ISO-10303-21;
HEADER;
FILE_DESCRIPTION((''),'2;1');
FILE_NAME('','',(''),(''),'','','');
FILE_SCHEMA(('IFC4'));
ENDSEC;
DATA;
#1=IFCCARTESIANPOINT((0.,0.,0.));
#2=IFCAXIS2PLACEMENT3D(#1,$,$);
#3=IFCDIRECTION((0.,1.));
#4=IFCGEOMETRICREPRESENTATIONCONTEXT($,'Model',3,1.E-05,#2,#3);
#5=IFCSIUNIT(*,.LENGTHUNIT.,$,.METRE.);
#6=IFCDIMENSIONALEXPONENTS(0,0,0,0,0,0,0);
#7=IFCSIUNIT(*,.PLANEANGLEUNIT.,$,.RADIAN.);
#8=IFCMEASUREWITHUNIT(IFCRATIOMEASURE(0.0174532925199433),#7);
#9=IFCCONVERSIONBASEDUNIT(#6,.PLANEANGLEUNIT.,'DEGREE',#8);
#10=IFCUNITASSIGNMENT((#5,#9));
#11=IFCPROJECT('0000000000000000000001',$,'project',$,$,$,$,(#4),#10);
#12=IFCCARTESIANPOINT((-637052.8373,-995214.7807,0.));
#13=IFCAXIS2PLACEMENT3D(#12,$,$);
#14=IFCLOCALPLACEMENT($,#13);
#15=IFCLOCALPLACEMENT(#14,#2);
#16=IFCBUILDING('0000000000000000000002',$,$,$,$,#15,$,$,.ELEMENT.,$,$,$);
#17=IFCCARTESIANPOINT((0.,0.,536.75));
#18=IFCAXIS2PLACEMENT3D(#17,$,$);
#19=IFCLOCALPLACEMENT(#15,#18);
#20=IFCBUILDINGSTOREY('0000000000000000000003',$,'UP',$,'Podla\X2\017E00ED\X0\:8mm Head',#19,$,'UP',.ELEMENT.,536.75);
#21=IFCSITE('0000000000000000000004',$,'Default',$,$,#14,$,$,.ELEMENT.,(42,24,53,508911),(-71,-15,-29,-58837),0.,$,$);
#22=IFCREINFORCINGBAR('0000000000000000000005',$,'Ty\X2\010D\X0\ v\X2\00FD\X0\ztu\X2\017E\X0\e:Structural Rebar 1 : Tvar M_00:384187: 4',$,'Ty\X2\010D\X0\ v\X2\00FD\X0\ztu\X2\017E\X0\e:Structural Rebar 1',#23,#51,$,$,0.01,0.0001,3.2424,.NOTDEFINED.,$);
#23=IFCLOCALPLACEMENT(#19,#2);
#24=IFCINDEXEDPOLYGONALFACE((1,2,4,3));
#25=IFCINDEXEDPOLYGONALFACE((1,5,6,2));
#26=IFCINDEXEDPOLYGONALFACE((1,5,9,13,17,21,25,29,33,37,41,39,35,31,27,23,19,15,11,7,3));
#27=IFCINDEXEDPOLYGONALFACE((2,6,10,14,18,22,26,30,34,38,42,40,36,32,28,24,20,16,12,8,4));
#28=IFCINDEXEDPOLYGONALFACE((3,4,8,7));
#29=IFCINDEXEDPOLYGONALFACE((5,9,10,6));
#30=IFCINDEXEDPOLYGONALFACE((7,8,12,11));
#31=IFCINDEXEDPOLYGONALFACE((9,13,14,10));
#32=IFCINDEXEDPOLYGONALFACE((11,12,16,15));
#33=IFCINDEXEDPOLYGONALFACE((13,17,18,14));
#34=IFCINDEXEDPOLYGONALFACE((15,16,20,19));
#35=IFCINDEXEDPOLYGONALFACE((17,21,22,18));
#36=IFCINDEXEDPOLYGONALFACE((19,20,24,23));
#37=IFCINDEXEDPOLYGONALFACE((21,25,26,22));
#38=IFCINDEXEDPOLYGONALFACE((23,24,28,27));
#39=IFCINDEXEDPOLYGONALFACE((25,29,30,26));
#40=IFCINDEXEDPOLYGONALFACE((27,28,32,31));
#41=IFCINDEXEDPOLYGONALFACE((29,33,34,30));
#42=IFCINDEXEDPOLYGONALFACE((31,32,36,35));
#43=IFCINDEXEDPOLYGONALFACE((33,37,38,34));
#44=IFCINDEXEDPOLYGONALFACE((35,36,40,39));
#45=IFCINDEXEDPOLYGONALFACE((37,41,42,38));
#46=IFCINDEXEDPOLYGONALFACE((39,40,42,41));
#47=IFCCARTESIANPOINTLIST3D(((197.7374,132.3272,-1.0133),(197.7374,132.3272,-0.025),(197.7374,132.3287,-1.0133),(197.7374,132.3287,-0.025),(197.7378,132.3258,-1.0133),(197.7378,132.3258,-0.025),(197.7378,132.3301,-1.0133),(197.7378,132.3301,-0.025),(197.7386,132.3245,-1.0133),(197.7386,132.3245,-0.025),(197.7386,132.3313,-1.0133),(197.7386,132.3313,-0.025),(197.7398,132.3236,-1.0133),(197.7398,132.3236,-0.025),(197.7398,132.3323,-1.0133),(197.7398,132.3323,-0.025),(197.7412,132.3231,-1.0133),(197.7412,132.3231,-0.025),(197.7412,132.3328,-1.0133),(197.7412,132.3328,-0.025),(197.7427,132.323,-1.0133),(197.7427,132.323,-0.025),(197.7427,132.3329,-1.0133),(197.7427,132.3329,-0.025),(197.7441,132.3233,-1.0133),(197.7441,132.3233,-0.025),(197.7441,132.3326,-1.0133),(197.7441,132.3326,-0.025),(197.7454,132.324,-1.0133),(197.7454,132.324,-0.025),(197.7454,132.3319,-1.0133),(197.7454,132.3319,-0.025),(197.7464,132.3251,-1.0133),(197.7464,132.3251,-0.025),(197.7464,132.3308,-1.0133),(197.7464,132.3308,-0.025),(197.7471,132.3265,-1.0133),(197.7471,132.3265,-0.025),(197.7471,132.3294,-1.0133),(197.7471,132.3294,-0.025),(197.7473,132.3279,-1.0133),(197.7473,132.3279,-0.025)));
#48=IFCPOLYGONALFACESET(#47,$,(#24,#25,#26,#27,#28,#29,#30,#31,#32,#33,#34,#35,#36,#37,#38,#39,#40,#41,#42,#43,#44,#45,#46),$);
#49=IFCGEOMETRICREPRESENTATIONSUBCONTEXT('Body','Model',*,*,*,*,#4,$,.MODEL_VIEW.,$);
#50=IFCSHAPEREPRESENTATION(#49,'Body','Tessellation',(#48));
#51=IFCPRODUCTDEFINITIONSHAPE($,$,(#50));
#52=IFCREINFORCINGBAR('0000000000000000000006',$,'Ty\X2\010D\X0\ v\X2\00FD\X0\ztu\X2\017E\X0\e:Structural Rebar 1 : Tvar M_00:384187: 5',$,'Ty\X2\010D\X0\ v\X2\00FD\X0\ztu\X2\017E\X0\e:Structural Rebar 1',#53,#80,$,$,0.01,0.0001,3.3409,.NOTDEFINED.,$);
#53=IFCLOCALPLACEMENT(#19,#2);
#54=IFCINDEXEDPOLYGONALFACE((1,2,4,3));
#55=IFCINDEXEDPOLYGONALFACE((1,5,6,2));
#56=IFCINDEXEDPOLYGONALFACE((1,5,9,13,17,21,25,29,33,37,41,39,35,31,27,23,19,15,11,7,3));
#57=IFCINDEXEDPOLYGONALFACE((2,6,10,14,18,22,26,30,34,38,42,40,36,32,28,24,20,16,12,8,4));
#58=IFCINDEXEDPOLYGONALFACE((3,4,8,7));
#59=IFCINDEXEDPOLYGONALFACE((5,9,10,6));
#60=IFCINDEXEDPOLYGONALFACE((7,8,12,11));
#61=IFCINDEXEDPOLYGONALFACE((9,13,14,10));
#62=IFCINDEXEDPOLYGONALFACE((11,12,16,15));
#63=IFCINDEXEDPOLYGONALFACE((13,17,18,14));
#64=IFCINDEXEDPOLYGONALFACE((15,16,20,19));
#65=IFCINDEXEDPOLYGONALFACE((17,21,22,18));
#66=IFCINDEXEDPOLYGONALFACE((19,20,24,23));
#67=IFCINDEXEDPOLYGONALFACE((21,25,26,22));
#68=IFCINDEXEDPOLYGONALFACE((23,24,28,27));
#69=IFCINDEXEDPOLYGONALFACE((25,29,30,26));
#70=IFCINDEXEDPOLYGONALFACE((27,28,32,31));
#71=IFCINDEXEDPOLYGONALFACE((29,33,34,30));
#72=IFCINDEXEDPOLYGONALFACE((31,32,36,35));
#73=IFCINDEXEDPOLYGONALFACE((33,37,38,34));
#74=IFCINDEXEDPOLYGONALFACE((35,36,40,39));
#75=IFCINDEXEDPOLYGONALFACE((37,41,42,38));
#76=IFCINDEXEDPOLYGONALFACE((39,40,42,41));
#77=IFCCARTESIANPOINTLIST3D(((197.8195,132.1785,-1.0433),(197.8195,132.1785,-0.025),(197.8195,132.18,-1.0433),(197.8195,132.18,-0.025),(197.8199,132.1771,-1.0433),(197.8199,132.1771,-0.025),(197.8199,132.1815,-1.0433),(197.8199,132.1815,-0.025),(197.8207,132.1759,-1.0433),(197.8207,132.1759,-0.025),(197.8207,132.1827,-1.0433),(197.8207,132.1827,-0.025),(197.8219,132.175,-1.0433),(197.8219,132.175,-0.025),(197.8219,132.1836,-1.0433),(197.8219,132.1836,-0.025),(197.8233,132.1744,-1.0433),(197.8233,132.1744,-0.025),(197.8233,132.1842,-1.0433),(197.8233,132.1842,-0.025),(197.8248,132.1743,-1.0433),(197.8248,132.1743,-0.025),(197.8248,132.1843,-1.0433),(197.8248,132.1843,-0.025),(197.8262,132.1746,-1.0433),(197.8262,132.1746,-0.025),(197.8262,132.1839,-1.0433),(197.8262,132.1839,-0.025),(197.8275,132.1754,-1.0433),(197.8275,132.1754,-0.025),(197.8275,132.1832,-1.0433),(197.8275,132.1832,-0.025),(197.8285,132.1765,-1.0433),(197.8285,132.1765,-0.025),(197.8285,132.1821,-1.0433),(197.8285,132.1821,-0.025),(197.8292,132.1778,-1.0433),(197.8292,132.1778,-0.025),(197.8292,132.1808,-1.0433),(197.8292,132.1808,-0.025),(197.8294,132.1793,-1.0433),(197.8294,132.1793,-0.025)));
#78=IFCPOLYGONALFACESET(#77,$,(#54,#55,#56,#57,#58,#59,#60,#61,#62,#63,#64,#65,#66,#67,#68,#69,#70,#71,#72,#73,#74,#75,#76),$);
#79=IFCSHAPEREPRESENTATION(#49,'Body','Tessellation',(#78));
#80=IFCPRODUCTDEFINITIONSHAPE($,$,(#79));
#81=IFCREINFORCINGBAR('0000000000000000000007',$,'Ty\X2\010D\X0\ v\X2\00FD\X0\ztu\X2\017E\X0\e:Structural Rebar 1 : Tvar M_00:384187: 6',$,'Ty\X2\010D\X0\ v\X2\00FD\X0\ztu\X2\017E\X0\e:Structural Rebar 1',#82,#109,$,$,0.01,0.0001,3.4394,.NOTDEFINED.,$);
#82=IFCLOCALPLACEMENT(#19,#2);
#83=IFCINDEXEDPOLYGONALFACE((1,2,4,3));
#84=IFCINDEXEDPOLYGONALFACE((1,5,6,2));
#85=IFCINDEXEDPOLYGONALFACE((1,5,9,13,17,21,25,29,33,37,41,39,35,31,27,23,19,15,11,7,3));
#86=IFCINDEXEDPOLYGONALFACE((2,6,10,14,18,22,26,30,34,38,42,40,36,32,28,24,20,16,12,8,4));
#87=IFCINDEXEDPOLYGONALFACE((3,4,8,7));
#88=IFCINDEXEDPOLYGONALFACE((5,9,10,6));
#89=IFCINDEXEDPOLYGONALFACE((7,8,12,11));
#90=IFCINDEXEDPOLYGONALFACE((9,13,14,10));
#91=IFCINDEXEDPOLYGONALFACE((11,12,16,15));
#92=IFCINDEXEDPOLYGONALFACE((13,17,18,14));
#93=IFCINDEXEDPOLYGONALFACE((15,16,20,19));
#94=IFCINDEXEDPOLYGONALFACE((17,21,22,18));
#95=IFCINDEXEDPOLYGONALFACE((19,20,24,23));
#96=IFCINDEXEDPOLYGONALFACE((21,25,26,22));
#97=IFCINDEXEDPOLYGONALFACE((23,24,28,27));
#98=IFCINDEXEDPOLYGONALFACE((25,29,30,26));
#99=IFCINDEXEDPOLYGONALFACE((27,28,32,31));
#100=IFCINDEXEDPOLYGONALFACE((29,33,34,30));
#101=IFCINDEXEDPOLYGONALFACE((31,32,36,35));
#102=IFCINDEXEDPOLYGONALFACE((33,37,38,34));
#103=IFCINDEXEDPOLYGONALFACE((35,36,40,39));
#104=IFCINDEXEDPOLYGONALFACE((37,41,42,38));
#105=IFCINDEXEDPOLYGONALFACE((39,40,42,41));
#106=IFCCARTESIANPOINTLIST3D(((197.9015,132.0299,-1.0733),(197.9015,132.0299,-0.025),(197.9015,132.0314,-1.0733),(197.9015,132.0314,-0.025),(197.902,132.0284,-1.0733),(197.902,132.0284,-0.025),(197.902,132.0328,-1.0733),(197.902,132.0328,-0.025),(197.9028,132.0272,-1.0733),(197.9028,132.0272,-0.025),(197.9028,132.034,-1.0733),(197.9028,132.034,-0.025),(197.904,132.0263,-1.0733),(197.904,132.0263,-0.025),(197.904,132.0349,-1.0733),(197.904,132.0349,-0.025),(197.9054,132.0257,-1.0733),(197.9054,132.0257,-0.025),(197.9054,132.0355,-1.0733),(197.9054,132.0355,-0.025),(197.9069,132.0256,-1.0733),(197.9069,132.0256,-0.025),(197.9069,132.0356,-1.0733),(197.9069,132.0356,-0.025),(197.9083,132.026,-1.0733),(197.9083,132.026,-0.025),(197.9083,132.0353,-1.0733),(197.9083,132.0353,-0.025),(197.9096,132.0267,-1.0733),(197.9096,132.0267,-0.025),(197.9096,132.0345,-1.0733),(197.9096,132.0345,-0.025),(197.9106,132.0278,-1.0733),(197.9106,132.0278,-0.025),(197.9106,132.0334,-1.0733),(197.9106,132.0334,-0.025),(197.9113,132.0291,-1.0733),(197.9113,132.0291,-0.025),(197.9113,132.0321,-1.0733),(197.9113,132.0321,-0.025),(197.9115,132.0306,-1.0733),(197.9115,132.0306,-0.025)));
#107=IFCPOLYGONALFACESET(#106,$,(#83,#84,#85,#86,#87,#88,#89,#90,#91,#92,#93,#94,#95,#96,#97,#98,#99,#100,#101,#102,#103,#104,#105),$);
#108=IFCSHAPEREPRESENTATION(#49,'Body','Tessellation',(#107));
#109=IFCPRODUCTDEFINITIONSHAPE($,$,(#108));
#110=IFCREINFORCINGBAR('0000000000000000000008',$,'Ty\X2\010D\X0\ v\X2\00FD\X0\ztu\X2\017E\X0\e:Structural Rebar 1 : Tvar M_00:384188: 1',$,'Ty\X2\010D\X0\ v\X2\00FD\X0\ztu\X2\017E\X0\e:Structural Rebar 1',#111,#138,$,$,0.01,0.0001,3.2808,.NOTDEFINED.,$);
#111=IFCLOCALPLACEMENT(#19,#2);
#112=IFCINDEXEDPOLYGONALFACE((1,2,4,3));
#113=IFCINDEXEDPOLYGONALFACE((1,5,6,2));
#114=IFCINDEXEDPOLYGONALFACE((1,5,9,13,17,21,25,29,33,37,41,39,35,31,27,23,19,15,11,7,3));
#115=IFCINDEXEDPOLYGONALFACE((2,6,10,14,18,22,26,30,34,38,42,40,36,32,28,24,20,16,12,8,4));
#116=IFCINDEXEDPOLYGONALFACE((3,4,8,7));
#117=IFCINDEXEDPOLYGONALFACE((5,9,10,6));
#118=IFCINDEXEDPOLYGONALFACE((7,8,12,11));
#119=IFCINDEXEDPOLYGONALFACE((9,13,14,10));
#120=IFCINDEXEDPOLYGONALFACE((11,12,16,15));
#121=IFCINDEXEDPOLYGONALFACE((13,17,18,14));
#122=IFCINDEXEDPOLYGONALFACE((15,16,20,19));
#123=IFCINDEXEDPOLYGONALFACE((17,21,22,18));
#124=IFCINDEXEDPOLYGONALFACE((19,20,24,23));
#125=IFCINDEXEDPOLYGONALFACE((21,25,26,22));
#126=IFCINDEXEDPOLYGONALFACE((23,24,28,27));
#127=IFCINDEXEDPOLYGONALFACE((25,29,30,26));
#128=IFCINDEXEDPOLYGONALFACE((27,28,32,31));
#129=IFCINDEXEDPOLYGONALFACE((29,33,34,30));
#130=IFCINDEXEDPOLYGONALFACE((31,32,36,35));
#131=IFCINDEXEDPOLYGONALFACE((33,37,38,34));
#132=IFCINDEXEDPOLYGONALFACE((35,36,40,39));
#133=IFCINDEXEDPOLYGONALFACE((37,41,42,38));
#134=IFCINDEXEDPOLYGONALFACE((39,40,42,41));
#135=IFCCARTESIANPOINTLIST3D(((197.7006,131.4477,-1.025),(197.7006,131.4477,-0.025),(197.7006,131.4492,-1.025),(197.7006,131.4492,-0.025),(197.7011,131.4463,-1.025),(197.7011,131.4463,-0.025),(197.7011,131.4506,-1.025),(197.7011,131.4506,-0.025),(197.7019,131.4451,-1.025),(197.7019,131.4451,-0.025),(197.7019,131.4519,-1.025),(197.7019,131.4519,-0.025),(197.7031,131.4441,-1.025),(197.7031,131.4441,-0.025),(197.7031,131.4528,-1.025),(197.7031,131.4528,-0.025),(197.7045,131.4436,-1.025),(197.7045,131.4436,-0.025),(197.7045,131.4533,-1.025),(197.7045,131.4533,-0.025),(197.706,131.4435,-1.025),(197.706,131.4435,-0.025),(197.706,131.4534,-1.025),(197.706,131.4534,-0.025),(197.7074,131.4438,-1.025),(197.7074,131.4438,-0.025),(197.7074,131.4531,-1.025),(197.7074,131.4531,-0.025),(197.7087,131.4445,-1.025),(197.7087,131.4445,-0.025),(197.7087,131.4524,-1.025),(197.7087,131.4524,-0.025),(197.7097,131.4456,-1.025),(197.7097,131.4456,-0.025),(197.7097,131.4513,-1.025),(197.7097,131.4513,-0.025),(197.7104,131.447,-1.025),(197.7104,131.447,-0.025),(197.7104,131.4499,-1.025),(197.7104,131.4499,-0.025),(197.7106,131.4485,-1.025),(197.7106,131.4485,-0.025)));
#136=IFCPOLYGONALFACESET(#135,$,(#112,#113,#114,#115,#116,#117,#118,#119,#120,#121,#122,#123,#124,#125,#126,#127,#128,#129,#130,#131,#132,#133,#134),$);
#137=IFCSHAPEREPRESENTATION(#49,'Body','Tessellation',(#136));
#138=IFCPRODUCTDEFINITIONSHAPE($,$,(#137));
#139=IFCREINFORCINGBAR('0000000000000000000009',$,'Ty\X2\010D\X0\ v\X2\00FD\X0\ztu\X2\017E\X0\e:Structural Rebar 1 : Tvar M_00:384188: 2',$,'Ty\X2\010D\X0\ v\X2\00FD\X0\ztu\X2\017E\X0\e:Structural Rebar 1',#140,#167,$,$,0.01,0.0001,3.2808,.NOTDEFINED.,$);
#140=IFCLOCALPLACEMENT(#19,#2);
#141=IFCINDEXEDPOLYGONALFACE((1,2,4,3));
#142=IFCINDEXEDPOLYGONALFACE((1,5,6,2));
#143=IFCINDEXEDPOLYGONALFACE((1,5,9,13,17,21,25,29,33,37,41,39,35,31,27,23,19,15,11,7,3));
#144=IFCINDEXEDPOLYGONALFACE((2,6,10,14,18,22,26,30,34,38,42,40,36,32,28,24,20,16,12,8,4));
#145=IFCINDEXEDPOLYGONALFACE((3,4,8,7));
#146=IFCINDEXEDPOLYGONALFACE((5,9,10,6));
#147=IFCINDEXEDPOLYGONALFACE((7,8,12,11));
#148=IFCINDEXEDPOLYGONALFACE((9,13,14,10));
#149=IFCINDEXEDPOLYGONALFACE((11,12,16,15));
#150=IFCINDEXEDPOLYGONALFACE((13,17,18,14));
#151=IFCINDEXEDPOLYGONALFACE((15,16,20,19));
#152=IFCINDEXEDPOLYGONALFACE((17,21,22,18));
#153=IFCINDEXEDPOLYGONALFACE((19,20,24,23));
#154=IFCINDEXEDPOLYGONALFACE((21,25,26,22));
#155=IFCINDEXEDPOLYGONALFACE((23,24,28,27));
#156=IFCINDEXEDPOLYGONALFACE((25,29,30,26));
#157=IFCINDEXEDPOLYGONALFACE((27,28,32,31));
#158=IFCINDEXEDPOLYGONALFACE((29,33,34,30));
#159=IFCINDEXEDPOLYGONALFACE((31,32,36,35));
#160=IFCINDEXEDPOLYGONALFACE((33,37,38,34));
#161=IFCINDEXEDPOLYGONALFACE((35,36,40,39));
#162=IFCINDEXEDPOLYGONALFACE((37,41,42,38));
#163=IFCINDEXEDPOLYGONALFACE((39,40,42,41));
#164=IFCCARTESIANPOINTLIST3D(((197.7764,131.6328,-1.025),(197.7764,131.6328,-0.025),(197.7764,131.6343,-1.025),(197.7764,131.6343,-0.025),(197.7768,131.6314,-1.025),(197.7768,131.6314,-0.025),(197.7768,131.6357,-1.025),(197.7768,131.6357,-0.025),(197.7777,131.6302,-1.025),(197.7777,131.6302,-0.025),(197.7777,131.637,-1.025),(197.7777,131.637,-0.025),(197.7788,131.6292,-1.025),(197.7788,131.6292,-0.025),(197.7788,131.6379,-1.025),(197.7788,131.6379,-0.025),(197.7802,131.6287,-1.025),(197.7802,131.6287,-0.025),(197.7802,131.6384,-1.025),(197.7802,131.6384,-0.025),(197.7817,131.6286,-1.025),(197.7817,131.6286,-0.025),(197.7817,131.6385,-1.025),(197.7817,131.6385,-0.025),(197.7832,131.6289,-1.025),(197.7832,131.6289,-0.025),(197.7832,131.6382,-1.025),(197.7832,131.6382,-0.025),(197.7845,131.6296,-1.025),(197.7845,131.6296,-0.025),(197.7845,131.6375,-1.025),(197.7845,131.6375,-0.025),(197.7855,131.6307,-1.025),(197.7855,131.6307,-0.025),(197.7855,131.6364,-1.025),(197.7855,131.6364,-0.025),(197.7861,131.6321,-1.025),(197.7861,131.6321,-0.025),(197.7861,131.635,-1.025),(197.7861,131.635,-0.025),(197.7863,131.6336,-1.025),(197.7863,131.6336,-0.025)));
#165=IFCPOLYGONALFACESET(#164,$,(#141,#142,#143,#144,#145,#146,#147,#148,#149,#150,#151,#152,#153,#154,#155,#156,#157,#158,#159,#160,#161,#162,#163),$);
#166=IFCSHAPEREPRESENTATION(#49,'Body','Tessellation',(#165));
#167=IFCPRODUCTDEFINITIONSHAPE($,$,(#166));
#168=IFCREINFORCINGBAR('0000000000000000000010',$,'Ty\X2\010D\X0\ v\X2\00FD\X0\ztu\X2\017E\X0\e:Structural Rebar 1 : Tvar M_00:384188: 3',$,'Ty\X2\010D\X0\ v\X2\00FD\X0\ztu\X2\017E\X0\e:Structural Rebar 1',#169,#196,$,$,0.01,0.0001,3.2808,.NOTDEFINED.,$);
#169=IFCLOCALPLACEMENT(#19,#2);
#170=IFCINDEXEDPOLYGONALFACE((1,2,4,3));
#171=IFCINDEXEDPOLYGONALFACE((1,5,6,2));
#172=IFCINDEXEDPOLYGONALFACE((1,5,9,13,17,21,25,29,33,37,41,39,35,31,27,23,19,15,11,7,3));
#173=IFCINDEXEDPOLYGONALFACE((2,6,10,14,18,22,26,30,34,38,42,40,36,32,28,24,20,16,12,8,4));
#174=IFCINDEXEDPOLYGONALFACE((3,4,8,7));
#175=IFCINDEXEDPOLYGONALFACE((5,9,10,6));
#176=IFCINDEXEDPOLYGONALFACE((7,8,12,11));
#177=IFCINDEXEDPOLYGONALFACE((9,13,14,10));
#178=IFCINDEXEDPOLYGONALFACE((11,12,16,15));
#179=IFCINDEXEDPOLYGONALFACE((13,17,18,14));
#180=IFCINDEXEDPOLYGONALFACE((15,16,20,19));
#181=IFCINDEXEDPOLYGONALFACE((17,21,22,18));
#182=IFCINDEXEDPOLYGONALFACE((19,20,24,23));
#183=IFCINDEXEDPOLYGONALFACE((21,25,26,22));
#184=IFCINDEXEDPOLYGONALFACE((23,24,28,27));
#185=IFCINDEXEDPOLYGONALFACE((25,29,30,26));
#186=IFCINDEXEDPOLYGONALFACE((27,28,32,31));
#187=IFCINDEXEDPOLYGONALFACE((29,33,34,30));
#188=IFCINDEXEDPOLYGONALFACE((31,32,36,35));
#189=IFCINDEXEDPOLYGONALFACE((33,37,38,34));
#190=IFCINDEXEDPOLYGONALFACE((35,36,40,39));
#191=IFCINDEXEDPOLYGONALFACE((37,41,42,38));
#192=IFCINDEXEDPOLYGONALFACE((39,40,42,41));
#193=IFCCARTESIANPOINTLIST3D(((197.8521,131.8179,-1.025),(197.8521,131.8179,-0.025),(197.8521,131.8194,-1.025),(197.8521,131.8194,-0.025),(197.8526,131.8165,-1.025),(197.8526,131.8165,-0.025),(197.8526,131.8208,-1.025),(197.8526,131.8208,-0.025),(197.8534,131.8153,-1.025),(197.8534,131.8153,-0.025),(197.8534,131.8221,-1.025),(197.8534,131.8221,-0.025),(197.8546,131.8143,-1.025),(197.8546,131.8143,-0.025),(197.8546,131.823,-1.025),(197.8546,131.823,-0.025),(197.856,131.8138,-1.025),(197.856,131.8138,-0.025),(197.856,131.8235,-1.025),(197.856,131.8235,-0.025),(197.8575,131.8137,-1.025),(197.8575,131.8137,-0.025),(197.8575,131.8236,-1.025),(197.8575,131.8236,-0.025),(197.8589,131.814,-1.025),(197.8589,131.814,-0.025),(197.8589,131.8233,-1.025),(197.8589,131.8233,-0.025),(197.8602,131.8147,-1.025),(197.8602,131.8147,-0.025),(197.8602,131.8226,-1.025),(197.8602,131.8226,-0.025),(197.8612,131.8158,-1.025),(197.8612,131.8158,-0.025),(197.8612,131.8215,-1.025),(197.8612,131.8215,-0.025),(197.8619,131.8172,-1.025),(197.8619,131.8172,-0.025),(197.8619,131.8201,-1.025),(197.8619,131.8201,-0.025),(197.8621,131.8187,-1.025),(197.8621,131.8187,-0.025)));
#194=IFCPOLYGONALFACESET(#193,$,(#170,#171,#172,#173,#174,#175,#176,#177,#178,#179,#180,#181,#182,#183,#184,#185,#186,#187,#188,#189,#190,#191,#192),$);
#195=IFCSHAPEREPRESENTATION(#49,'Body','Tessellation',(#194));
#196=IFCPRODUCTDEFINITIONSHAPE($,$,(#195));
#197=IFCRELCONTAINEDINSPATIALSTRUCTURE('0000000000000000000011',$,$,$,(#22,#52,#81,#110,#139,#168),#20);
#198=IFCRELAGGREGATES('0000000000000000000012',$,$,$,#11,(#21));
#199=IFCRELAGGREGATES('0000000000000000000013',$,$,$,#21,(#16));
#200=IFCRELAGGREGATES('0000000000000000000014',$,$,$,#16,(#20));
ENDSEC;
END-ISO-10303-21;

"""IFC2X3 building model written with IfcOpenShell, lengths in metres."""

from ifc_helpers import new_model, entity, si_unit, converted_unit, direction, frame, origin, place, context, subcontext, project, spatial, element, save


model = new_model("IFC2X3")

# Units and contexts
model_context = context("Model", 3, precision=1e-05, world=origin(), true_north=direction((0.0, 1.0)))
body_context = subcontext(model_context, "Body", "Model", "MODEL_VIEW")
ifc_project = project(units=[si_unit("LENGTHUNIT", "METRE"), converted_unit("PLANEANGLEUNIT", "DEGREE", entity("IfcRatioMeasure", 0.0174532925199433), si_unit("PLANEANGLEUNIT", "RADIAN"), dimensions=[0, 0, 0, 0, 0, 0, 0])], contexts=[model_context])

# Site, building, storey
site_placement = place(None, frame((-637052.8373, -995214.7807, 0.0)))
site = spatial("IfcSite", under=ifc_project, at=site_placement, Name="Default", CompositionType="ELEMENT", RefLatitude=(42, 24, 53, 508911), RefLongitude=(-71, -15, -29, -58837), RefElevation=0.0)
building_placement = place(site_placement, origin())
building = spatial("IfcBuilding", under=site, at=building_placement, CompositionType="ELEMENT")
storey_placement = place(building_placement, frame((0.0, 0.0, 536.75)))
storey = spatial("IfcBuildingStorey", under=building, at=storey_placement, Name="UP", ObjectType="Podlaží:8mm Head", LongName="UP", CompositionType="ELEMENT", Elevation=536.75)

# Reinforcing bars
reinforcing_bar_1_placement = place(storey_placement, origin())
element("IfcReinforcingBar", 1, at=reinforcing_bar_1_placement, inside=storey, Name="Tyč výztuže:Structural Rebar 1 : Tvar M_00:384187: 4", ObjectType="Tyč výztuže:Structural Rebar 1", BarLength=3.2424, BarRole="NOTDEFINED", CrossSectionArea=0.0001, NominalDiameter=0.01, context=body_context, shape_type="AdvancedSweptSolid", body=[
    entity("IfcSweptDiskSolid", entity("IfcCompositeCurve", [entity("IfcCompositeCurveSegment", "CONTINUOUS", True, entity("IfcPolyline", [entity("IfcCartesianPoint", [-197.7423, -132.3279, 0.025]), entity("IfcCartesianPoint", [-197.7423, -132.3279, 1.0133])]))], False), 0.005, None, 0.0, 1.0),
])
reinforcing_bar_2_placement = place(storey_placement, origin())
element("IfcReinforcingBar", 2, at=reinforcing_bar_2_placement, inside=storey, Name="Tyč výztuže:Structural Rebar 1 : Tvar M_00:384187: 5", ObjectType="Tyč výztuže:Structural Rebar 1", BarLength=3.3409, BarRole="NOTDEFINED", CrossSectionArea=0.0001, NominalDiameter=0.01, context=body_context, shape_type="AdvancedSweptSolid", body=[
    entity("IfcSweptDiskSolid", entity("IfcCompositeCurve", [entity("IfcCompositeCurveSegment", "CONTINUOUS", True, entity("IfcPolyline", [entity("IfcCartesianPoint", [-197.8244, -132.1793, 0.025]), entity("IfcCartesianPoint", [-197.8244, -132.1793, 1.0433])]))], False), 0.005, None, 0.0, 1.0),
])
reinforcing_bar_3_placement = place(storey_placement, origin())
element("IfcReinforcingBar", 3, at=reinforcing_bar_3_placement, inside=storey, Name="Tyč výztuže:Structural Rebar 1 : Tvar M_00:384187: 6", ObjectType="Tyč výztuže:Structural Rebar 1", BarLength=3.4394, BarRole="NOTDEFINED", CrossSectionArea=0.0001, NominalDiameter=0.01, context=body_context, shape_type="AdvancedSweptSolid", body=[
    entity("IfcSweptDiskSolid", entity("IfcCompositeCurve", [entity("IfcCompositeCurveSegment", "CONTINUOUS", True, entity("IfcPolyline", [entity("IfcCartesianPoint", [-197.9065, -132.0306, 0.025]), entity("IfcCartesianPoint", [-197.9065, -132.0306, 1.0733])]))], False), 0.005, None, 0.0, 1.0),
])
reinforcing_bar_4_placement = place(storey_placement, origin())
element("IfcReinforcingBar", 4, at=reinforcing_bar_4_placement, inside=storey, Name="Tyč výztuže:Structural Rebar 1 : Tvar M_00:384188: 1", ObjectType="Tyč výztuže:Structural Rebar 1", BarLength=3.2808, BarRole="NOTDEFINED", CrossSectionArea=0.0001, NominalDiameter=0.01, context=body_context, shape_type="AdvancedSweptSolid", body=[
    entity("IfcSweptDiskSolid", entity("IfcCompositeCurve", [entity("IfcCompositeCurveSegment", "CONTINUOUS", True, entity("IfcPolyline", [entity("IfcCartesianPoint", [-197.7056, -131.4485, 0.025]), entity("IfcCartesianPoint", [-197.7056, -131.4485, 1.025])]))], False), 0.005, None, 0.0, 1.0),
])
reinforcing_bar_5_placement = place(storey_placement, origin())
element("IfcReinforcingBar", 5, at=reinforcing_bar_5_placement, inside=storey, Name="Tyč výztuže:Structural Rebar 1 : Tvar M_00:384188: 2", ObjectType="Tyč výztuže:Structural Rebar 1", BarLength=3.2808, BarRole="NOTDEFINED", CrossSectionArea=0.0001, NominalDiameter=0.01, context=body_context, shape_type="AdvancedSweptSolid", body=[
    entity("IfcSweptDiskSolid", entity("IfcCompositeCurve", [entity("IfcCompositeCurveSegment", "CONTINUOUS", True, entity("IfcPolyline", [entity("IfcCartesianPoint", [-197.7813, -131.6336, 0.025]), entity("IfcCartesianPoint", [-197.7813, -131.6336, 1.025])]))], False), 0.005, None, 0.0, 1.0),
])
reinforcing_bar_6_placement = place(storey_placement, origin())
element("IfcReinforcingBar", 6, at=reinforcing_bar_6_placement, inside=storey, Name="Tyč výztuže:Structural Rebar 1 : Tvar M_00:384188: 3", ObjectType="Tyč výztuže:Structural Rebar 1", BarLength=3.2808, BarRole="NOTDEFINED", CrossSectionArea=0.0001, NominalDiameter=0.01, context=body_context, shape_type="AdvancedSweptSolid", body=[
    entity("IfcSweptDiskSolid", entity("IfcCompositeCurve", [entity("IfcCompositeCurveSegment", "CONTINUOUS", True, entity("IfcPolyline", [entity("IfcCartesianPoint", [-197.8571, -131.8187, 0.025]), entity("IfcCartesianPoint", [-197.8571, -131.8187, 1.025])]))], False), 0.005, None, 0.0, 1.0),
])

save(model, "model.ifc")
